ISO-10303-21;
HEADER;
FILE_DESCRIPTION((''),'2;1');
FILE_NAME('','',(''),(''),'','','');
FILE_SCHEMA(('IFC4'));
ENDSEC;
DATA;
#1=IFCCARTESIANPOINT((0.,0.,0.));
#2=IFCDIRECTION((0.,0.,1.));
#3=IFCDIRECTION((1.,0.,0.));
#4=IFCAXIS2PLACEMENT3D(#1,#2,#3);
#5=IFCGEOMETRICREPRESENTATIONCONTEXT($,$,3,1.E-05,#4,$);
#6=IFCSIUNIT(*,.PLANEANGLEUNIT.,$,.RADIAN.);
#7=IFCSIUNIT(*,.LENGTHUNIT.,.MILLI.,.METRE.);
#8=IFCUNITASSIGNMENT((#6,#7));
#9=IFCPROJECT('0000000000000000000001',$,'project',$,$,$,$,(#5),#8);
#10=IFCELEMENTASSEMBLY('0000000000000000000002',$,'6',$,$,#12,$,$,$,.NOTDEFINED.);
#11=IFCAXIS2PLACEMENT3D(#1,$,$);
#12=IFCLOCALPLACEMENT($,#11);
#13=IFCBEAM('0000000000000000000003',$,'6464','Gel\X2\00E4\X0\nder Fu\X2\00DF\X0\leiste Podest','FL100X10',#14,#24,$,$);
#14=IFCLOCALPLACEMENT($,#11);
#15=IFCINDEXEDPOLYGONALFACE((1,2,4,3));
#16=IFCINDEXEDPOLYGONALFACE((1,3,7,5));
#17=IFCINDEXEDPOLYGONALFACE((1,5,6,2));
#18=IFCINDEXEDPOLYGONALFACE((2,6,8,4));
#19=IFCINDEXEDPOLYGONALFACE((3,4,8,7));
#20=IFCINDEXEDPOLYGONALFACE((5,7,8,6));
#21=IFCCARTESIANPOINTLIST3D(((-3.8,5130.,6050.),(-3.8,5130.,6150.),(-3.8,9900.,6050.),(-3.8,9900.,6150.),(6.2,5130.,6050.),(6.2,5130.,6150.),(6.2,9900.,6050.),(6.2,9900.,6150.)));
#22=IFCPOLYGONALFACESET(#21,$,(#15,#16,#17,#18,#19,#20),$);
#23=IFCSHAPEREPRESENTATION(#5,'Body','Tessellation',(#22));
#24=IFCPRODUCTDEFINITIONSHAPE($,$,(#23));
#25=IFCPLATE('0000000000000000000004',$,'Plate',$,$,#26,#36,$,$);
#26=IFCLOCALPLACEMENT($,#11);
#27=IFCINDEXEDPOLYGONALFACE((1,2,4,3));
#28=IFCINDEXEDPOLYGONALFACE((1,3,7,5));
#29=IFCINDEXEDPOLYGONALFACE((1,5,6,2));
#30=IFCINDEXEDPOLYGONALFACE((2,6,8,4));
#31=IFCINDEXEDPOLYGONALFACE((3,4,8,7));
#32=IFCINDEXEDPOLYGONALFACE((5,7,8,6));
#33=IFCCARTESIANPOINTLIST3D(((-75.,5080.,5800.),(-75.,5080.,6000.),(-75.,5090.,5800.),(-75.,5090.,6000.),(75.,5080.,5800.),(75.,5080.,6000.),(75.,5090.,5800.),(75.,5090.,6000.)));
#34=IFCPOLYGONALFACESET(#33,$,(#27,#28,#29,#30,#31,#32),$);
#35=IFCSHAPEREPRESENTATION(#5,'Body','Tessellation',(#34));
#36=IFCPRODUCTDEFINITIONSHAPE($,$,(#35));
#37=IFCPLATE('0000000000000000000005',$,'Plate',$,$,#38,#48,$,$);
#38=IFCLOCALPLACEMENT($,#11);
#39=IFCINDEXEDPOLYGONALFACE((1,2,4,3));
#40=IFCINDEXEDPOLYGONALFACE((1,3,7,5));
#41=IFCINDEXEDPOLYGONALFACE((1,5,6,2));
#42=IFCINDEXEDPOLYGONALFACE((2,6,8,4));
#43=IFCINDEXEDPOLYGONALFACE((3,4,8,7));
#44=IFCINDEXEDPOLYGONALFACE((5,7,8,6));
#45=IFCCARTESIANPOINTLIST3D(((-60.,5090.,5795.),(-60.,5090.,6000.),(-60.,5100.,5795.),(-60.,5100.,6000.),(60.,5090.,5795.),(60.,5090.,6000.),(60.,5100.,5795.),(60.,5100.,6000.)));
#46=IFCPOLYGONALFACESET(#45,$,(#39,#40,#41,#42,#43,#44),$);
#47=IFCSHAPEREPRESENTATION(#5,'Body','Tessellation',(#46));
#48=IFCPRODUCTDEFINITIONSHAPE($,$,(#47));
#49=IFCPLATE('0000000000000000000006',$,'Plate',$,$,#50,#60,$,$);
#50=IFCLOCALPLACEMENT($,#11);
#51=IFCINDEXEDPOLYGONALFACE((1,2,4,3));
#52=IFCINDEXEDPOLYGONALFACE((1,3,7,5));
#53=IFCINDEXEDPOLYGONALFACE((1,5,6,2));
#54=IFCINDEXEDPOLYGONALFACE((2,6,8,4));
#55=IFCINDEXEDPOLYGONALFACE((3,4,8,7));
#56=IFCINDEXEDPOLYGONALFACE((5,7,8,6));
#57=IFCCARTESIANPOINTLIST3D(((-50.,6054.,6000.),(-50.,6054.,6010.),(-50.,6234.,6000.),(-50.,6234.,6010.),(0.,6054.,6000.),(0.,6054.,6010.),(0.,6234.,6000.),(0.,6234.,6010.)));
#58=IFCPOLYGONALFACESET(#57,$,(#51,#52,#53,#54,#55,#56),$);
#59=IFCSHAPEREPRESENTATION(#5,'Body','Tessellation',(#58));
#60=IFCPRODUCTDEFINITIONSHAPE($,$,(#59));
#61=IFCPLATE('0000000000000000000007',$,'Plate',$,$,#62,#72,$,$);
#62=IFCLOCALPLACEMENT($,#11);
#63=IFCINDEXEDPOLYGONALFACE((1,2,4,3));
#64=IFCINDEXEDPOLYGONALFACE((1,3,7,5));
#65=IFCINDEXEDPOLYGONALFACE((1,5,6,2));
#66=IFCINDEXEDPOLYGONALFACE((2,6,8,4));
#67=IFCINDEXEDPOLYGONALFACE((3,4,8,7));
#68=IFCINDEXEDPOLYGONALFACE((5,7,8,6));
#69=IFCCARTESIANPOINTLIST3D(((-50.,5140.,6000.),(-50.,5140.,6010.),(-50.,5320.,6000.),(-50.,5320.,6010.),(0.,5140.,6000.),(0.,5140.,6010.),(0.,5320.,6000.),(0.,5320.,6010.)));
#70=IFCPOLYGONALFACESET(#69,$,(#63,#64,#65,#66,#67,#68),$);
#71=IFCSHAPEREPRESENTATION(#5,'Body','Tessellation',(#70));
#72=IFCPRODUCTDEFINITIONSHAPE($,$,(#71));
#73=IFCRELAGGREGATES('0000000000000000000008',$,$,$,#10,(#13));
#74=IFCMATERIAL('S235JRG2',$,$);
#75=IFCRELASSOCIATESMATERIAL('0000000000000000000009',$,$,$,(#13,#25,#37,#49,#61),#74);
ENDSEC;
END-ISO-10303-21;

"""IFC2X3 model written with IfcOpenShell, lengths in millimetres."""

from ifc_helpers import new_model, si_unit, frame, origin_with_axes, place, context, project, polyline, outline, extrude, material, element, aggregate, save


model = new_model("IFC2X3")

# Units and contexts
context_of_model = context(None, 3, precision=1e-05, world=origin_with_axes())
ifc_project = project(units=[si_unit("PLANEANGLEUNIT", "RADIAN"), si_unit("LENGTHUNIT", "METRE", prefix="MILLI")], contexts=[context_of_model])

# Element assembly, beam
assembly_placement = place(None, frame((1.2, 5130.0, 6100.0), z_axis=(0.0, 0.0, 1.0), x_axis=(0.0, 1.0, 0.0)))
assembly = element("IfcElementAssembly", 1, at=assembly_placement, Name="6", PredefinedType="NOTDEFINED")
ifc_material = material(Name="S235JRG2")
placement_1 = place(None, frame((1.2, 5130.0, 6100.0), z_axis=(0.0, 0.0, 1.0), x_axis=(0.0, 1.0, 0.0)))
beam_1_placement = place(placement_1, origin_with_axes())
beam_1 = element("IfcBeam", 2, at=beam_1_placement, material=ifc_material, Name="6464", Description="Geländer Fußleiste Podest", ObjectType="FL100X10", context=context_of_model, shape_type="SweptSolid", body=[
    extrude(outline(polyline([(5.0, -50.0), (5.0, 50.0), (-5.0, 50.0), (-5.0, -50.0), (5.0, -50.0), (5.0, -50.0)])), frame((0.0, 0.0, 0.0), z_axis=(1.0, 0.0, 0.0), x_axis=(0.0, 1.0, 0.0)), (0.0, 0.0, 1.0), 4770.0),
])
aggregate(assembly, [beam_1])

# Plates
placement_2 = place(None, origin_with_axes())
plate_1_placement = place(placement_2, frame((-75.0, 5080.0, 6000.0), z_axis=(0.0, 0.0, -1.0), x_axis=(0.0, 1.0, 0.0)))
element("IfcPlate", 3, at=plate_1_placement, material=ifc_material, Name="Plate", context=context_of_model, shape_type="SweptSolid", body=[
    extrude(outline(polyline([(0.0, 0.0), (150.0, 0.0), (150.0, 200.0), (0.0, 200.0), (0.0, 0.0)])), frame((0.0, 0.0, 0.0), z_axis=(1.0, 0.0, 0.0), x_axis=(0.0, 1.0, 0.0)), (0.0, 0.0, 1.0), 10.0),
])
placement_3 = place(None, origin_with_axes())
plate_2_placement = place(placement_3, frame((60.0, 5100.0, 6000.0), z_axis=(0.0, 0.0, -1.0), x_axis=(0.0, -1.0, 0.0)))
element("IfcPlate", 4, at=plate_2_placement, material=ifc_material, Name="Plate", context=context_of_model, shape_type="SweptSolid", body=[
    extrude(outline(polyline([(0.0, 0.0), (120.0, 0.0), (120.0, 205.0), (0.0, 205.0), (0.0, 0.0)])), frame((0.0, 0.0, 0.0), z_axis=(1.0, 0.0, 0.0), x_axis=(0.0, 1.0, 0.0)), (0.0, 0.0, 1.0), 10.0),
])
placement_4 = place(None, origin_with_axes())
plate_3_placement = place(placement_4, frame((0.0, 6234.0, 6010.0), z_axis=(-1.0, 0.0, 0.0), x_axis=(0.0, 0.0, -1.0)))
element("IfcPlate", 5, at=plate_3_placement, material=ifc_material, Name="Plate", context=context_of_model, shape_type="SweptSolid", body=[
    extrude(outline(polyline([(0.0, 0.0), (180.0, 0.0), (180.0, 50.0), (0.0, 50.0), (0.0, 0.0)])), frame((0.0, 0.0, 0.0), z_axis=(1.0, 0.0, 0.0), x_axis=(0.0, 1.0, 0.0)), (0.0, 0.0, 1.0), 10.0),
])
placement_5 = place(None, origin_with_axes())
plate_4_placement = place(placement_5, frame((0.0, 5320.0, 6010.0), z_axis=(-1.0, 0.0, 0.0), x_axis=(0.0, 0.0, -1.0)))
element("IfcPlate", 6, at=plate_4_placement, material=ifc_material, Name="Plate", context=context_of_model, shape_type="SweptSolid", body=[
    extrude(outline(polyline([(0.0, 0.0), (180.0, 0.0), (180.0, 50.0), (0.0, 50.0), (0.0, 0.0)])), frame((0.0, 0.0, 0.0), z_axis=(1.0, 0.0, 0.0), x_axis=(0.0, 1.0, 0.0)), (0.0, 0.0, 1.0), 10.0),
])

save(model, "model.ifc")
